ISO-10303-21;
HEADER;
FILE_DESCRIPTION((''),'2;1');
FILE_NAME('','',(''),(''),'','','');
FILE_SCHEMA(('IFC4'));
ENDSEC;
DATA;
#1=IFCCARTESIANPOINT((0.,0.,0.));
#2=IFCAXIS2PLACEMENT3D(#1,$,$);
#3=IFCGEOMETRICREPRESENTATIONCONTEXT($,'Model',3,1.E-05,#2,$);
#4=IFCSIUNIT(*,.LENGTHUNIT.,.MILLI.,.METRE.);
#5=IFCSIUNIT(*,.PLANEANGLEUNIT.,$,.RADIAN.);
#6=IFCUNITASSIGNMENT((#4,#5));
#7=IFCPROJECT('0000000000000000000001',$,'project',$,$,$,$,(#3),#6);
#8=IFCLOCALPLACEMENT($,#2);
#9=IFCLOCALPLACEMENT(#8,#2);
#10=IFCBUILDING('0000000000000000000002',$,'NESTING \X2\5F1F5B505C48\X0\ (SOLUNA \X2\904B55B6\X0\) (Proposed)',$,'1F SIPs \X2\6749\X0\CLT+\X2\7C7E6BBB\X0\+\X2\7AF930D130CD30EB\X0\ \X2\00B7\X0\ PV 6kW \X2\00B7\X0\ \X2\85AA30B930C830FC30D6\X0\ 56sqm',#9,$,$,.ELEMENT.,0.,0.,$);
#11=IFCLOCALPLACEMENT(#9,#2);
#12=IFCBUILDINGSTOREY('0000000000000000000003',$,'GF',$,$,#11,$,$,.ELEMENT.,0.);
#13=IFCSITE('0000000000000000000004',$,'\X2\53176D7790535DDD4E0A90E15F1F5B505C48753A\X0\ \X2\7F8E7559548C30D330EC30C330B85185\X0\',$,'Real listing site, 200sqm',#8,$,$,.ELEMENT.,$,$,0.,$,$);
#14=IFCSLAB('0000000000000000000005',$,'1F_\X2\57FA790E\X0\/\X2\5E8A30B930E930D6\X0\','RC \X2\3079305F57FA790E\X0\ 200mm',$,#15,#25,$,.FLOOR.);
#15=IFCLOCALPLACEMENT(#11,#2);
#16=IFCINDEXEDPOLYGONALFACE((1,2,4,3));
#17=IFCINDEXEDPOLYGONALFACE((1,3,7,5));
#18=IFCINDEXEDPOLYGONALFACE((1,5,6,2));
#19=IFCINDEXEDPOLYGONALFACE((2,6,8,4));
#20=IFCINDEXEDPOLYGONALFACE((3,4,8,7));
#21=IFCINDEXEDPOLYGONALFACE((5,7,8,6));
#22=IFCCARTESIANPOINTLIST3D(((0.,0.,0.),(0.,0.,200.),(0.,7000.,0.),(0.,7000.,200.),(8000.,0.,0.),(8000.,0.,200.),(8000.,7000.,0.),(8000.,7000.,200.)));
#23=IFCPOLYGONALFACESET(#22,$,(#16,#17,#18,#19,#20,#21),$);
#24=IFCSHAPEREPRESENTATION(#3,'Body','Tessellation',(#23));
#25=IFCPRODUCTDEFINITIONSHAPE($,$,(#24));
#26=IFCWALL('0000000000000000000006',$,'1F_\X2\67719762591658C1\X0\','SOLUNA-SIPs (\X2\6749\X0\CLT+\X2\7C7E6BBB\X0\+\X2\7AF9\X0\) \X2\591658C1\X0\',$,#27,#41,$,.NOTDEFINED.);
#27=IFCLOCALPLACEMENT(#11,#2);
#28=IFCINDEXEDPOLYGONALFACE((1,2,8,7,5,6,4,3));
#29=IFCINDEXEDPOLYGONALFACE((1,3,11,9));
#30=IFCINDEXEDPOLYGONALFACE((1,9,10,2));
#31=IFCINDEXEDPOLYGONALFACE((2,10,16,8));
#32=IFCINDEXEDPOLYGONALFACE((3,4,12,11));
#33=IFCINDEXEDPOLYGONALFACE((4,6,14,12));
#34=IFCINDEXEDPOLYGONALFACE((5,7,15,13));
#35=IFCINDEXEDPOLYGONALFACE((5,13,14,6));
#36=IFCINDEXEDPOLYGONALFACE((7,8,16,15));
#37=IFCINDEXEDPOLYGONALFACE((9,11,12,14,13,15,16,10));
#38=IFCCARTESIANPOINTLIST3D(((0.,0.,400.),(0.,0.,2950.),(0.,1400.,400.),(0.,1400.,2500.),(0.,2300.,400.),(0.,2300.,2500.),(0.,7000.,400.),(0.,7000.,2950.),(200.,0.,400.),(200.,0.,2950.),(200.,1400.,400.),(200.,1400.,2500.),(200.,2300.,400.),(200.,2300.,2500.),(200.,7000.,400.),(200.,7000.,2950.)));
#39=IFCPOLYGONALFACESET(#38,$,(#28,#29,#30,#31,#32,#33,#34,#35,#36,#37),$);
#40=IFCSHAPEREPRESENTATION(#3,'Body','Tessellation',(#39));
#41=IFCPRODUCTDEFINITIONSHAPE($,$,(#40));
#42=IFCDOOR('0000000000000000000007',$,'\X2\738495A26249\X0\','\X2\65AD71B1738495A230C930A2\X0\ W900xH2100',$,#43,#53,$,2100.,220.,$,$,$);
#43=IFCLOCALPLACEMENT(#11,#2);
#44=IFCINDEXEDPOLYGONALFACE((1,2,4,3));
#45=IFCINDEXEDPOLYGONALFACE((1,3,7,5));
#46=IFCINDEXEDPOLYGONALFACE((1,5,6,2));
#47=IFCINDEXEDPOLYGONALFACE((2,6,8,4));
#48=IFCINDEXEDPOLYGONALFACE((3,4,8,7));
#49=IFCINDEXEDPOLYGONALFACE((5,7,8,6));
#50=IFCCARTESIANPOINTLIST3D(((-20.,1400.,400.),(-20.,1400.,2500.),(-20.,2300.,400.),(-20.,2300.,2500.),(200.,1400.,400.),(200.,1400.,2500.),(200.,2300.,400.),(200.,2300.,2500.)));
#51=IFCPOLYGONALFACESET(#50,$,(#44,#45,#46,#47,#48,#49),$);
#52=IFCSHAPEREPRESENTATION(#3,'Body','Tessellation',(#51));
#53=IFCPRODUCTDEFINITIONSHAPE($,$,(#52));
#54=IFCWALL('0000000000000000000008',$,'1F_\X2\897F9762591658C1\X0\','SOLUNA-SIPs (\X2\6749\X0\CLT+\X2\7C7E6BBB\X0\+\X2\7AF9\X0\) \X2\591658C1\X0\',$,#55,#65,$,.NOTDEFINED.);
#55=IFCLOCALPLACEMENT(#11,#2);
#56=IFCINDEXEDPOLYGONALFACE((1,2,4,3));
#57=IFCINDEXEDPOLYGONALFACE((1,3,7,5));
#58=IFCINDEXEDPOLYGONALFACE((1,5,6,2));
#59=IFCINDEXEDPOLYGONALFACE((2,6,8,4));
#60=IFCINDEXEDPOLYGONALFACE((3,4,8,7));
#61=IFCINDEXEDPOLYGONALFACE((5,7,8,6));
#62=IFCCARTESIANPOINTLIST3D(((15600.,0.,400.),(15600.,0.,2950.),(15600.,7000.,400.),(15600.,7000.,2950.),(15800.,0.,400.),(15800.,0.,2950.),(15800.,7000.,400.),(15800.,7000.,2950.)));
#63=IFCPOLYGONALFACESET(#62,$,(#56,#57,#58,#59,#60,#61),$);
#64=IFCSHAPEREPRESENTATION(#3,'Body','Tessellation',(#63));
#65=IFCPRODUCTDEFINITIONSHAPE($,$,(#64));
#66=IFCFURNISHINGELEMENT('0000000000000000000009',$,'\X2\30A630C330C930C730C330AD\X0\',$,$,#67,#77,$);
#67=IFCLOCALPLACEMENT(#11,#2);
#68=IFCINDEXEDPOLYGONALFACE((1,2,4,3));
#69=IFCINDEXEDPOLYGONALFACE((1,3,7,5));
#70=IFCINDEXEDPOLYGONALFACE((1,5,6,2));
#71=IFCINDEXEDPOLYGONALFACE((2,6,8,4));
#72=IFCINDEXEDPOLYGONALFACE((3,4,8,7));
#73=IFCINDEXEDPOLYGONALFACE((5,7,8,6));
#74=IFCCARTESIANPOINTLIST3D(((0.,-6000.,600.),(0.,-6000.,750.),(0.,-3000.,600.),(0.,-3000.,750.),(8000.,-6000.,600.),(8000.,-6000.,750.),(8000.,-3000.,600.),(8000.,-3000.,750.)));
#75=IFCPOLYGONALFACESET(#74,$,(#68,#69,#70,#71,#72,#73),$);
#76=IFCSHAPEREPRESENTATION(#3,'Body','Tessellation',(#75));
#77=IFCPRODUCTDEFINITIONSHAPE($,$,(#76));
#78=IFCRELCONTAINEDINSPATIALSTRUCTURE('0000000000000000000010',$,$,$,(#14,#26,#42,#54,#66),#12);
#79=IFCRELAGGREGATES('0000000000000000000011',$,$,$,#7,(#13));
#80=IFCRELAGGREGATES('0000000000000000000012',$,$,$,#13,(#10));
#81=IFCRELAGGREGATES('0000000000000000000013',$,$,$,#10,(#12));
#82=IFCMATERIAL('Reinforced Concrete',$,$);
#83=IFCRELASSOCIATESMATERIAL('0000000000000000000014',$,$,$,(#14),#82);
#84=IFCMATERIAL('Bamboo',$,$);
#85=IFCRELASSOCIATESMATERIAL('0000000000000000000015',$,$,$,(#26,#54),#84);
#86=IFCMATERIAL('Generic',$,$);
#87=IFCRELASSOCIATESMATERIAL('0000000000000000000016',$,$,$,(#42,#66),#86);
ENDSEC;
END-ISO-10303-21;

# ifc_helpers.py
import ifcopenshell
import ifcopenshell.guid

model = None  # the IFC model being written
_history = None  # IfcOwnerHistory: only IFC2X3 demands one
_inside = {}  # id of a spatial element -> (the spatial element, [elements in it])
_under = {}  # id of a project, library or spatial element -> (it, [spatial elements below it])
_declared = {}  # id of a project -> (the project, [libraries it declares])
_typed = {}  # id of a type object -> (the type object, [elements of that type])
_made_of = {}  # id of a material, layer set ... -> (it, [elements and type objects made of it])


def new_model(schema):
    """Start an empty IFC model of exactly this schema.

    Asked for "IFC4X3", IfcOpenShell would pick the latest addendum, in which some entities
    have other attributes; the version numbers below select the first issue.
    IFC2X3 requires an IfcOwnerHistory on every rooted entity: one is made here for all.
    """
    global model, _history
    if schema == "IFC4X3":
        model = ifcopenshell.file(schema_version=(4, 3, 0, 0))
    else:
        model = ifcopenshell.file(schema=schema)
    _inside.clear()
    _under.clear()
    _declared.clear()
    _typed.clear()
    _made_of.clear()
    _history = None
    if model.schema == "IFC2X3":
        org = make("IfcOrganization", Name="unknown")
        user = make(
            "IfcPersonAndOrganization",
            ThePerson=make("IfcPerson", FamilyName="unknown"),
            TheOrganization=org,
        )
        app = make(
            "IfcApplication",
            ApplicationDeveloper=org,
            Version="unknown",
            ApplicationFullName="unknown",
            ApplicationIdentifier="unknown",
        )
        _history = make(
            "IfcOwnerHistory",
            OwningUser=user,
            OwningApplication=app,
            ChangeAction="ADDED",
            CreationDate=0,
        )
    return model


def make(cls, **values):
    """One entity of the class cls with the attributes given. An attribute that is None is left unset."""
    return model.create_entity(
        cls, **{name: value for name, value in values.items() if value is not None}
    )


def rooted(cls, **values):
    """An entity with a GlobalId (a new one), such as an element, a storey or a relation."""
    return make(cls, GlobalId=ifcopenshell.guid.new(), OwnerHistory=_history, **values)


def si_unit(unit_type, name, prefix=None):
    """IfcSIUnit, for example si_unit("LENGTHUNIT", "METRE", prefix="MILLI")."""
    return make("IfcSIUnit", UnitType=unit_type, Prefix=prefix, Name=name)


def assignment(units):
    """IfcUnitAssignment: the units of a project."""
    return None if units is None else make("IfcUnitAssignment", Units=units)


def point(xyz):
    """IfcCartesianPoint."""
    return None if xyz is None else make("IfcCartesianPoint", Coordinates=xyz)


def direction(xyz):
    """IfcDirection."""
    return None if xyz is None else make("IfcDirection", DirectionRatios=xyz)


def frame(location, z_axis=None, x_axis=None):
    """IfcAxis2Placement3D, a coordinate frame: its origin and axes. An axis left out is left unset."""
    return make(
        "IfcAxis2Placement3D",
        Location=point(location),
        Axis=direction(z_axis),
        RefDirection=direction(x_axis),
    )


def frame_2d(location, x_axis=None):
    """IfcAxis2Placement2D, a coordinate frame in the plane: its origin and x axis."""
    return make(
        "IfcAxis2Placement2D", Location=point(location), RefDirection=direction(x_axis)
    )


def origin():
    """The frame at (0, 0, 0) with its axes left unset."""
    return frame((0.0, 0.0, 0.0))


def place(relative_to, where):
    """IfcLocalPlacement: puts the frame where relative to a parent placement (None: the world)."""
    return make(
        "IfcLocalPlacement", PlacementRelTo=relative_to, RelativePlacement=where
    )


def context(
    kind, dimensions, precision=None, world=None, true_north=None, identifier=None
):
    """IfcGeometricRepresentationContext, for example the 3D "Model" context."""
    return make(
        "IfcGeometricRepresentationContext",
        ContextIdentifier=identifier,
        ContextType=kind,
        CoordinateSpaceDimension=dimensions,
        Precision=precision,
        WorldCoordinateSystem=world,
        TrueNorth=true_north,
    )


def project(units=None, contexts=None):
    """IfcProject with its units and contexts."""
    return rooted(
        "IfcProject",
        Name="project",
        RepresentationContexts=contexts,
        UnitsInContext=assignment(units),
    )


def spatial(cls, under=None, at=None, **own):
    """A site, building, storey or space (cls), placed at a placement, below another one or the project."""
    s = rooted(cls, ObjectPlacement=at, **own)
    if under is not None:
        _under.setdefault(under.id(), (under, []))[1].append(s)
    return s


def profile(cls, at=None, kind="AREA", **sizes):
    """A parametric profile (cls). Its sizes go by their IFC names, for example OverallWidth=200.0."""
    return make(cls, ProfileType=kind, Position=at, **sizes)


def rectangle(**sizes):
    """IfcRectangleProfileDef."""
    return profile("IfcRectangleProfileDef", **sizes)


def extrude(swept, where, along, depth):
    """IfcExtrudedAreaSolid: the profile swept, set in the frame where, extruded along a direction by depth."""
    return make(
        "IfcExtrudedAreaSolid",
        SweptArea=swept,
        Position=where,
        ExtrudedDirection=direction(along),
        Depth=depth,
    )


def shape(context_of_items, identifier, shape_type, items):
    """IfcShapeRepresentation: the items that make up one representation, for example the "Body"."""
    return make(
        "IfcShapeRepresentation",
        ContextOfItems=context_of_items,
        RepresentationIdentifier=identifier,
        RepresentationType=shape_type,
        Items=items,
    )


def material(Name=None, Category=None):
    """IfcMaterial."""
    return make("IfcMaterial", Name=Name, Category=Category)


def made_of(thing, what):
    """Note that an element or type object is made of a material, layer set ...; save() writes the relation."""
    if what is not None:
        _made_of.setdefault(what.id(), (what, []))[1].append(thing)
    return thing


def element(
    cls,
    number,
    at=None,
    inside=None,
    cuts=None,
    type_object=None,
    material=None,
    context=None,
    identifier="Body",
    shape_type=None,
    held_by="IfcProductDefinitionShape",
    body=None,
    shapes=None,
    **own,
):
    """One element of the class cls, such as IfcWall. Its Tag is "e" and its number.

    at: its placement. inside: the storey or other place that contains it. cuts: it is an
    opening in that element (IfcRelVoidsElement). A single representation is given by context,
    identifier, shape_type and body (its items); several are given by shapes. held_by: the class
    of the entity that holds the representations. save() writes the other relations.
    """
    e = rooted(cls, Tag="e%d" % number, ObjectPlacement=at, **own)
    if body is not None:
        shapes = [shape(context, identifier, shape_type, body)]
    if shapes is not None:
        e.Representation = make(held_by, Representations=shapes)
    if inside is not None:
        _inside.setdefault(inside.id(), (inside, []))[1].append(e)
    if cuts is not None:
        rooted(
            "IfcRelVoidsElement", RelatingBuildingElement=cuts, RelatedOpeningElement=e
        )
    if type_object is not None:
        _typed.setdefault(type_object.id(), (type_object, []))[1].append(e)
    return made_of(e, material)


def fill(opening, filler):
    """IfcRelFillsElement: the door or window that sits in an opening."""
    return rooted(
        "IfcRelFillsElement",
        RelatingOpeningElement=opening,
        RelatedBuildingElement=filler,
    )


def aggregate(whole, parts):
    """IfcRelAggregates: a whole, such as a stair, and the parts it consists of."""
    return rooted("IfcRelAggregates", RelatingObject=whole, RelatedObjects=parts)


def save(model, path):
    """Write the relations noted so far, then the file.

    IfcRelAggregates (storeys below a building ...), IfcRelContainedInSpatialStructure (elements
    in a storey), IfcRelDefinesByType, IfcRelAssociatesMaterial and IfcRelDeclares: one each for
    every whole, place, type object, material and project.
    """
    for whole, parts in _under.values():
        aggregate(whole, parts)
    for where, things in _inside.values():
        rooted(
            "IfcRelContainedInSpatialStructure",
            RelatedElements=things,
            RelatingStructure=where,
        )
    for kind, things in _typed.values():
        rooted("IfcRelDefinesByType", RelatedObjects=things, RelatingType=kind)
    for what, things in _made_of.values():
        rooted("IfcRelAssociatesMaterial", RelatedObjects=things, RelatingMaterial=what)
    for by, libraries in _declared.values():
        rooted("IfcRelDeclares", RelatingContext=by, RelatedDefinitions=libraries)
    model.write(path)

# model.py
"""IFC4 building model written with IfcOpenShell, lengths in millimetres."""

from ifc_helpers import new_model, si_unit, frame, frame_2d, origin, place, context, project, spatial, rectangle, extrude, material, element, fill, save


model = new_model("IFC4")

# Units and contexts
model_context = context("Model", 3, precision=1e-05, world=origin())
ifc_project = project(units=[si_unit("LENGTHUNIT", "METRE", prefix="MILLI"), si_unit("PLANEANGLEUNIT", "RADIAN")], contexts=[model_context])

# Site, building, storey
site_placement = place(None, origin())
site = spatial("IfcSite", under=ifc_project, at=site_placement, Name="北海道川上郡弟子屈町 美留和ビレッジ内", ObjectType="Real listing site, 200sqm", CompositionType="ELEMENT", RefElevation=0.0)
building_placement = place(site_placement, origin())
building = spatial("IfcBuilding", under=site, at=building_placement, Name="NESTING 弟子屈 (SOLUNA 運営) (Proposed)", ObjectType="1F SIPs 杉CLT+籾殻+竹パネル · PV 6kW · 薪ストーブ 56sqm", CompositionType="ELEMENT", ElevationOfRefHeight=0.0, ElevationOfTerrain=0.0)
storey_placement = place(building_placement, origin())
storey = spatial("IfcBuildingStorey", under=building, at=storey_placement, Name="GF", CompositionType="ELEMENT", Elevation=0.0)

# Slab
ifc_material_1 = material(Name="Reinforced Concrete")
slab_placement = place(storey_placement, origin())
element("IfcSlab", 1, at=slab_placement, inside=storey, material=ifc_material_1, Name="1F_基礎/床スラブ", Description="RC べた基礎 200mm", PredefinedType="FLOOR", context=model_context, shape_type="SweptSolid", body=[
    extrude(rectangle(XDim=8000.0, YDim=7000.0, at=frame_2d((4000.0, 3500.0))), origin(), (0.0, 0.0, 1.0), 200.0),
])

# Shared definitions
ifc_material_2 = material(Name="Bamboo")
ifc_material_3 = material(Name="Generic")

# Wall, opening, door
wall_1_placement = place(storey_placement, frame((0.0, 0.0, 200.0)))
wall_1 = element("IfcWall", 2, at=wall_1_placement, inside=storey, material=ifc_material_2, Name="1F_東面外壁", Description="SOLUNA-SIPs (杉CLT+籾殻+竹) 外壁", PredefinedType="NOTDEFINED", context=model_context, shape_type="SweptSolid", body=[
    extrude(rectangle(XDim=200.0, YDim=7000.0, at=frame_2d((100.0, 3500.0))), frame((0.0, 0.0, 200.0)), (0.0, 0.0, 1.0), 2550.0),
])
opening_1_placement = place(storey_placement, frame((-10.0, 700.0, 200.0)))
opening_1 = element("IfcOpeningElement", 3, at=opening_1_placement, cuts=wall_1, PredefinedType="NOTDEFINED", context=model_context, shape_type="SweptSolid", body=[
    extrude(rectangle(XDim=220.0, YDim=900.0, at=frame_2d((110.0, 450.0))), frame((-10.0, 700.0, 200.0)), (0.0, 0.0, 1.0), 2100.0),
])
door_placement = place(storey_placement, frame((-10.0, 700.0, 200.0)))
door = element("IfcDoor", 4, at=door_placement, inside=storey, material=ifc_material_3, Name="玄関扉", Description="断熱玄関ドア W900xH2100", OverallHeight=2100.0, OverallWidth=220.0, context=model_context, shape_type="SweptSolid", body=[
    extrude(rectangle(XDim=220.0, YDim=900.0, at=frame_2d((110.0, 450.0))), frame((-10.0, 700.0, 200.0)), (0.0, 0.0, 1.0), 2100.0),
])
fill(opening_1, door)

# Wall
wall_2_placement = place(storey_placement, frame((7800.0, 0.0, 200.0)))
element("IfcWall", 5, at=wall_2_placement, inside=storey, material=ifc_material_2, Name="1F_西面外壁", Description="SOLUNA-SIPs (杉CLT+籾殻+竹) 外壁", PredefinedType="NOTDEFINED", context=model_context, shape_type="SweptSolid", body=[
    extrude(rectangle(XDim=200.0, YDim=7000.0, at=frame_2d((100.0, 3500.0))), frame((7800.0, 0.0, 200.0)), (0.0, 0.0, 1.0), 2550.0),
])

# Furnishing element
furnishing_1_placement = place(storey_placement, frame((0.0, -3000.0, 300.0)))
element("IfcFurnishingElement", 6, at=furnishing_1_placement, inside=storey, material=ifc_material_3, Name="ウッドデッキ", context=model_context, shape_type="SweptSolid", body=[
    extrude(rectangle(XDim=8000.0, YDim=3000.0, at=frame_2d((4000.0, 1500.0))), frame((0.0, -3000.0, 300.0)), (0.0, 0.0, 1.0), 150.0),
])

save(model, "model.ifc")
